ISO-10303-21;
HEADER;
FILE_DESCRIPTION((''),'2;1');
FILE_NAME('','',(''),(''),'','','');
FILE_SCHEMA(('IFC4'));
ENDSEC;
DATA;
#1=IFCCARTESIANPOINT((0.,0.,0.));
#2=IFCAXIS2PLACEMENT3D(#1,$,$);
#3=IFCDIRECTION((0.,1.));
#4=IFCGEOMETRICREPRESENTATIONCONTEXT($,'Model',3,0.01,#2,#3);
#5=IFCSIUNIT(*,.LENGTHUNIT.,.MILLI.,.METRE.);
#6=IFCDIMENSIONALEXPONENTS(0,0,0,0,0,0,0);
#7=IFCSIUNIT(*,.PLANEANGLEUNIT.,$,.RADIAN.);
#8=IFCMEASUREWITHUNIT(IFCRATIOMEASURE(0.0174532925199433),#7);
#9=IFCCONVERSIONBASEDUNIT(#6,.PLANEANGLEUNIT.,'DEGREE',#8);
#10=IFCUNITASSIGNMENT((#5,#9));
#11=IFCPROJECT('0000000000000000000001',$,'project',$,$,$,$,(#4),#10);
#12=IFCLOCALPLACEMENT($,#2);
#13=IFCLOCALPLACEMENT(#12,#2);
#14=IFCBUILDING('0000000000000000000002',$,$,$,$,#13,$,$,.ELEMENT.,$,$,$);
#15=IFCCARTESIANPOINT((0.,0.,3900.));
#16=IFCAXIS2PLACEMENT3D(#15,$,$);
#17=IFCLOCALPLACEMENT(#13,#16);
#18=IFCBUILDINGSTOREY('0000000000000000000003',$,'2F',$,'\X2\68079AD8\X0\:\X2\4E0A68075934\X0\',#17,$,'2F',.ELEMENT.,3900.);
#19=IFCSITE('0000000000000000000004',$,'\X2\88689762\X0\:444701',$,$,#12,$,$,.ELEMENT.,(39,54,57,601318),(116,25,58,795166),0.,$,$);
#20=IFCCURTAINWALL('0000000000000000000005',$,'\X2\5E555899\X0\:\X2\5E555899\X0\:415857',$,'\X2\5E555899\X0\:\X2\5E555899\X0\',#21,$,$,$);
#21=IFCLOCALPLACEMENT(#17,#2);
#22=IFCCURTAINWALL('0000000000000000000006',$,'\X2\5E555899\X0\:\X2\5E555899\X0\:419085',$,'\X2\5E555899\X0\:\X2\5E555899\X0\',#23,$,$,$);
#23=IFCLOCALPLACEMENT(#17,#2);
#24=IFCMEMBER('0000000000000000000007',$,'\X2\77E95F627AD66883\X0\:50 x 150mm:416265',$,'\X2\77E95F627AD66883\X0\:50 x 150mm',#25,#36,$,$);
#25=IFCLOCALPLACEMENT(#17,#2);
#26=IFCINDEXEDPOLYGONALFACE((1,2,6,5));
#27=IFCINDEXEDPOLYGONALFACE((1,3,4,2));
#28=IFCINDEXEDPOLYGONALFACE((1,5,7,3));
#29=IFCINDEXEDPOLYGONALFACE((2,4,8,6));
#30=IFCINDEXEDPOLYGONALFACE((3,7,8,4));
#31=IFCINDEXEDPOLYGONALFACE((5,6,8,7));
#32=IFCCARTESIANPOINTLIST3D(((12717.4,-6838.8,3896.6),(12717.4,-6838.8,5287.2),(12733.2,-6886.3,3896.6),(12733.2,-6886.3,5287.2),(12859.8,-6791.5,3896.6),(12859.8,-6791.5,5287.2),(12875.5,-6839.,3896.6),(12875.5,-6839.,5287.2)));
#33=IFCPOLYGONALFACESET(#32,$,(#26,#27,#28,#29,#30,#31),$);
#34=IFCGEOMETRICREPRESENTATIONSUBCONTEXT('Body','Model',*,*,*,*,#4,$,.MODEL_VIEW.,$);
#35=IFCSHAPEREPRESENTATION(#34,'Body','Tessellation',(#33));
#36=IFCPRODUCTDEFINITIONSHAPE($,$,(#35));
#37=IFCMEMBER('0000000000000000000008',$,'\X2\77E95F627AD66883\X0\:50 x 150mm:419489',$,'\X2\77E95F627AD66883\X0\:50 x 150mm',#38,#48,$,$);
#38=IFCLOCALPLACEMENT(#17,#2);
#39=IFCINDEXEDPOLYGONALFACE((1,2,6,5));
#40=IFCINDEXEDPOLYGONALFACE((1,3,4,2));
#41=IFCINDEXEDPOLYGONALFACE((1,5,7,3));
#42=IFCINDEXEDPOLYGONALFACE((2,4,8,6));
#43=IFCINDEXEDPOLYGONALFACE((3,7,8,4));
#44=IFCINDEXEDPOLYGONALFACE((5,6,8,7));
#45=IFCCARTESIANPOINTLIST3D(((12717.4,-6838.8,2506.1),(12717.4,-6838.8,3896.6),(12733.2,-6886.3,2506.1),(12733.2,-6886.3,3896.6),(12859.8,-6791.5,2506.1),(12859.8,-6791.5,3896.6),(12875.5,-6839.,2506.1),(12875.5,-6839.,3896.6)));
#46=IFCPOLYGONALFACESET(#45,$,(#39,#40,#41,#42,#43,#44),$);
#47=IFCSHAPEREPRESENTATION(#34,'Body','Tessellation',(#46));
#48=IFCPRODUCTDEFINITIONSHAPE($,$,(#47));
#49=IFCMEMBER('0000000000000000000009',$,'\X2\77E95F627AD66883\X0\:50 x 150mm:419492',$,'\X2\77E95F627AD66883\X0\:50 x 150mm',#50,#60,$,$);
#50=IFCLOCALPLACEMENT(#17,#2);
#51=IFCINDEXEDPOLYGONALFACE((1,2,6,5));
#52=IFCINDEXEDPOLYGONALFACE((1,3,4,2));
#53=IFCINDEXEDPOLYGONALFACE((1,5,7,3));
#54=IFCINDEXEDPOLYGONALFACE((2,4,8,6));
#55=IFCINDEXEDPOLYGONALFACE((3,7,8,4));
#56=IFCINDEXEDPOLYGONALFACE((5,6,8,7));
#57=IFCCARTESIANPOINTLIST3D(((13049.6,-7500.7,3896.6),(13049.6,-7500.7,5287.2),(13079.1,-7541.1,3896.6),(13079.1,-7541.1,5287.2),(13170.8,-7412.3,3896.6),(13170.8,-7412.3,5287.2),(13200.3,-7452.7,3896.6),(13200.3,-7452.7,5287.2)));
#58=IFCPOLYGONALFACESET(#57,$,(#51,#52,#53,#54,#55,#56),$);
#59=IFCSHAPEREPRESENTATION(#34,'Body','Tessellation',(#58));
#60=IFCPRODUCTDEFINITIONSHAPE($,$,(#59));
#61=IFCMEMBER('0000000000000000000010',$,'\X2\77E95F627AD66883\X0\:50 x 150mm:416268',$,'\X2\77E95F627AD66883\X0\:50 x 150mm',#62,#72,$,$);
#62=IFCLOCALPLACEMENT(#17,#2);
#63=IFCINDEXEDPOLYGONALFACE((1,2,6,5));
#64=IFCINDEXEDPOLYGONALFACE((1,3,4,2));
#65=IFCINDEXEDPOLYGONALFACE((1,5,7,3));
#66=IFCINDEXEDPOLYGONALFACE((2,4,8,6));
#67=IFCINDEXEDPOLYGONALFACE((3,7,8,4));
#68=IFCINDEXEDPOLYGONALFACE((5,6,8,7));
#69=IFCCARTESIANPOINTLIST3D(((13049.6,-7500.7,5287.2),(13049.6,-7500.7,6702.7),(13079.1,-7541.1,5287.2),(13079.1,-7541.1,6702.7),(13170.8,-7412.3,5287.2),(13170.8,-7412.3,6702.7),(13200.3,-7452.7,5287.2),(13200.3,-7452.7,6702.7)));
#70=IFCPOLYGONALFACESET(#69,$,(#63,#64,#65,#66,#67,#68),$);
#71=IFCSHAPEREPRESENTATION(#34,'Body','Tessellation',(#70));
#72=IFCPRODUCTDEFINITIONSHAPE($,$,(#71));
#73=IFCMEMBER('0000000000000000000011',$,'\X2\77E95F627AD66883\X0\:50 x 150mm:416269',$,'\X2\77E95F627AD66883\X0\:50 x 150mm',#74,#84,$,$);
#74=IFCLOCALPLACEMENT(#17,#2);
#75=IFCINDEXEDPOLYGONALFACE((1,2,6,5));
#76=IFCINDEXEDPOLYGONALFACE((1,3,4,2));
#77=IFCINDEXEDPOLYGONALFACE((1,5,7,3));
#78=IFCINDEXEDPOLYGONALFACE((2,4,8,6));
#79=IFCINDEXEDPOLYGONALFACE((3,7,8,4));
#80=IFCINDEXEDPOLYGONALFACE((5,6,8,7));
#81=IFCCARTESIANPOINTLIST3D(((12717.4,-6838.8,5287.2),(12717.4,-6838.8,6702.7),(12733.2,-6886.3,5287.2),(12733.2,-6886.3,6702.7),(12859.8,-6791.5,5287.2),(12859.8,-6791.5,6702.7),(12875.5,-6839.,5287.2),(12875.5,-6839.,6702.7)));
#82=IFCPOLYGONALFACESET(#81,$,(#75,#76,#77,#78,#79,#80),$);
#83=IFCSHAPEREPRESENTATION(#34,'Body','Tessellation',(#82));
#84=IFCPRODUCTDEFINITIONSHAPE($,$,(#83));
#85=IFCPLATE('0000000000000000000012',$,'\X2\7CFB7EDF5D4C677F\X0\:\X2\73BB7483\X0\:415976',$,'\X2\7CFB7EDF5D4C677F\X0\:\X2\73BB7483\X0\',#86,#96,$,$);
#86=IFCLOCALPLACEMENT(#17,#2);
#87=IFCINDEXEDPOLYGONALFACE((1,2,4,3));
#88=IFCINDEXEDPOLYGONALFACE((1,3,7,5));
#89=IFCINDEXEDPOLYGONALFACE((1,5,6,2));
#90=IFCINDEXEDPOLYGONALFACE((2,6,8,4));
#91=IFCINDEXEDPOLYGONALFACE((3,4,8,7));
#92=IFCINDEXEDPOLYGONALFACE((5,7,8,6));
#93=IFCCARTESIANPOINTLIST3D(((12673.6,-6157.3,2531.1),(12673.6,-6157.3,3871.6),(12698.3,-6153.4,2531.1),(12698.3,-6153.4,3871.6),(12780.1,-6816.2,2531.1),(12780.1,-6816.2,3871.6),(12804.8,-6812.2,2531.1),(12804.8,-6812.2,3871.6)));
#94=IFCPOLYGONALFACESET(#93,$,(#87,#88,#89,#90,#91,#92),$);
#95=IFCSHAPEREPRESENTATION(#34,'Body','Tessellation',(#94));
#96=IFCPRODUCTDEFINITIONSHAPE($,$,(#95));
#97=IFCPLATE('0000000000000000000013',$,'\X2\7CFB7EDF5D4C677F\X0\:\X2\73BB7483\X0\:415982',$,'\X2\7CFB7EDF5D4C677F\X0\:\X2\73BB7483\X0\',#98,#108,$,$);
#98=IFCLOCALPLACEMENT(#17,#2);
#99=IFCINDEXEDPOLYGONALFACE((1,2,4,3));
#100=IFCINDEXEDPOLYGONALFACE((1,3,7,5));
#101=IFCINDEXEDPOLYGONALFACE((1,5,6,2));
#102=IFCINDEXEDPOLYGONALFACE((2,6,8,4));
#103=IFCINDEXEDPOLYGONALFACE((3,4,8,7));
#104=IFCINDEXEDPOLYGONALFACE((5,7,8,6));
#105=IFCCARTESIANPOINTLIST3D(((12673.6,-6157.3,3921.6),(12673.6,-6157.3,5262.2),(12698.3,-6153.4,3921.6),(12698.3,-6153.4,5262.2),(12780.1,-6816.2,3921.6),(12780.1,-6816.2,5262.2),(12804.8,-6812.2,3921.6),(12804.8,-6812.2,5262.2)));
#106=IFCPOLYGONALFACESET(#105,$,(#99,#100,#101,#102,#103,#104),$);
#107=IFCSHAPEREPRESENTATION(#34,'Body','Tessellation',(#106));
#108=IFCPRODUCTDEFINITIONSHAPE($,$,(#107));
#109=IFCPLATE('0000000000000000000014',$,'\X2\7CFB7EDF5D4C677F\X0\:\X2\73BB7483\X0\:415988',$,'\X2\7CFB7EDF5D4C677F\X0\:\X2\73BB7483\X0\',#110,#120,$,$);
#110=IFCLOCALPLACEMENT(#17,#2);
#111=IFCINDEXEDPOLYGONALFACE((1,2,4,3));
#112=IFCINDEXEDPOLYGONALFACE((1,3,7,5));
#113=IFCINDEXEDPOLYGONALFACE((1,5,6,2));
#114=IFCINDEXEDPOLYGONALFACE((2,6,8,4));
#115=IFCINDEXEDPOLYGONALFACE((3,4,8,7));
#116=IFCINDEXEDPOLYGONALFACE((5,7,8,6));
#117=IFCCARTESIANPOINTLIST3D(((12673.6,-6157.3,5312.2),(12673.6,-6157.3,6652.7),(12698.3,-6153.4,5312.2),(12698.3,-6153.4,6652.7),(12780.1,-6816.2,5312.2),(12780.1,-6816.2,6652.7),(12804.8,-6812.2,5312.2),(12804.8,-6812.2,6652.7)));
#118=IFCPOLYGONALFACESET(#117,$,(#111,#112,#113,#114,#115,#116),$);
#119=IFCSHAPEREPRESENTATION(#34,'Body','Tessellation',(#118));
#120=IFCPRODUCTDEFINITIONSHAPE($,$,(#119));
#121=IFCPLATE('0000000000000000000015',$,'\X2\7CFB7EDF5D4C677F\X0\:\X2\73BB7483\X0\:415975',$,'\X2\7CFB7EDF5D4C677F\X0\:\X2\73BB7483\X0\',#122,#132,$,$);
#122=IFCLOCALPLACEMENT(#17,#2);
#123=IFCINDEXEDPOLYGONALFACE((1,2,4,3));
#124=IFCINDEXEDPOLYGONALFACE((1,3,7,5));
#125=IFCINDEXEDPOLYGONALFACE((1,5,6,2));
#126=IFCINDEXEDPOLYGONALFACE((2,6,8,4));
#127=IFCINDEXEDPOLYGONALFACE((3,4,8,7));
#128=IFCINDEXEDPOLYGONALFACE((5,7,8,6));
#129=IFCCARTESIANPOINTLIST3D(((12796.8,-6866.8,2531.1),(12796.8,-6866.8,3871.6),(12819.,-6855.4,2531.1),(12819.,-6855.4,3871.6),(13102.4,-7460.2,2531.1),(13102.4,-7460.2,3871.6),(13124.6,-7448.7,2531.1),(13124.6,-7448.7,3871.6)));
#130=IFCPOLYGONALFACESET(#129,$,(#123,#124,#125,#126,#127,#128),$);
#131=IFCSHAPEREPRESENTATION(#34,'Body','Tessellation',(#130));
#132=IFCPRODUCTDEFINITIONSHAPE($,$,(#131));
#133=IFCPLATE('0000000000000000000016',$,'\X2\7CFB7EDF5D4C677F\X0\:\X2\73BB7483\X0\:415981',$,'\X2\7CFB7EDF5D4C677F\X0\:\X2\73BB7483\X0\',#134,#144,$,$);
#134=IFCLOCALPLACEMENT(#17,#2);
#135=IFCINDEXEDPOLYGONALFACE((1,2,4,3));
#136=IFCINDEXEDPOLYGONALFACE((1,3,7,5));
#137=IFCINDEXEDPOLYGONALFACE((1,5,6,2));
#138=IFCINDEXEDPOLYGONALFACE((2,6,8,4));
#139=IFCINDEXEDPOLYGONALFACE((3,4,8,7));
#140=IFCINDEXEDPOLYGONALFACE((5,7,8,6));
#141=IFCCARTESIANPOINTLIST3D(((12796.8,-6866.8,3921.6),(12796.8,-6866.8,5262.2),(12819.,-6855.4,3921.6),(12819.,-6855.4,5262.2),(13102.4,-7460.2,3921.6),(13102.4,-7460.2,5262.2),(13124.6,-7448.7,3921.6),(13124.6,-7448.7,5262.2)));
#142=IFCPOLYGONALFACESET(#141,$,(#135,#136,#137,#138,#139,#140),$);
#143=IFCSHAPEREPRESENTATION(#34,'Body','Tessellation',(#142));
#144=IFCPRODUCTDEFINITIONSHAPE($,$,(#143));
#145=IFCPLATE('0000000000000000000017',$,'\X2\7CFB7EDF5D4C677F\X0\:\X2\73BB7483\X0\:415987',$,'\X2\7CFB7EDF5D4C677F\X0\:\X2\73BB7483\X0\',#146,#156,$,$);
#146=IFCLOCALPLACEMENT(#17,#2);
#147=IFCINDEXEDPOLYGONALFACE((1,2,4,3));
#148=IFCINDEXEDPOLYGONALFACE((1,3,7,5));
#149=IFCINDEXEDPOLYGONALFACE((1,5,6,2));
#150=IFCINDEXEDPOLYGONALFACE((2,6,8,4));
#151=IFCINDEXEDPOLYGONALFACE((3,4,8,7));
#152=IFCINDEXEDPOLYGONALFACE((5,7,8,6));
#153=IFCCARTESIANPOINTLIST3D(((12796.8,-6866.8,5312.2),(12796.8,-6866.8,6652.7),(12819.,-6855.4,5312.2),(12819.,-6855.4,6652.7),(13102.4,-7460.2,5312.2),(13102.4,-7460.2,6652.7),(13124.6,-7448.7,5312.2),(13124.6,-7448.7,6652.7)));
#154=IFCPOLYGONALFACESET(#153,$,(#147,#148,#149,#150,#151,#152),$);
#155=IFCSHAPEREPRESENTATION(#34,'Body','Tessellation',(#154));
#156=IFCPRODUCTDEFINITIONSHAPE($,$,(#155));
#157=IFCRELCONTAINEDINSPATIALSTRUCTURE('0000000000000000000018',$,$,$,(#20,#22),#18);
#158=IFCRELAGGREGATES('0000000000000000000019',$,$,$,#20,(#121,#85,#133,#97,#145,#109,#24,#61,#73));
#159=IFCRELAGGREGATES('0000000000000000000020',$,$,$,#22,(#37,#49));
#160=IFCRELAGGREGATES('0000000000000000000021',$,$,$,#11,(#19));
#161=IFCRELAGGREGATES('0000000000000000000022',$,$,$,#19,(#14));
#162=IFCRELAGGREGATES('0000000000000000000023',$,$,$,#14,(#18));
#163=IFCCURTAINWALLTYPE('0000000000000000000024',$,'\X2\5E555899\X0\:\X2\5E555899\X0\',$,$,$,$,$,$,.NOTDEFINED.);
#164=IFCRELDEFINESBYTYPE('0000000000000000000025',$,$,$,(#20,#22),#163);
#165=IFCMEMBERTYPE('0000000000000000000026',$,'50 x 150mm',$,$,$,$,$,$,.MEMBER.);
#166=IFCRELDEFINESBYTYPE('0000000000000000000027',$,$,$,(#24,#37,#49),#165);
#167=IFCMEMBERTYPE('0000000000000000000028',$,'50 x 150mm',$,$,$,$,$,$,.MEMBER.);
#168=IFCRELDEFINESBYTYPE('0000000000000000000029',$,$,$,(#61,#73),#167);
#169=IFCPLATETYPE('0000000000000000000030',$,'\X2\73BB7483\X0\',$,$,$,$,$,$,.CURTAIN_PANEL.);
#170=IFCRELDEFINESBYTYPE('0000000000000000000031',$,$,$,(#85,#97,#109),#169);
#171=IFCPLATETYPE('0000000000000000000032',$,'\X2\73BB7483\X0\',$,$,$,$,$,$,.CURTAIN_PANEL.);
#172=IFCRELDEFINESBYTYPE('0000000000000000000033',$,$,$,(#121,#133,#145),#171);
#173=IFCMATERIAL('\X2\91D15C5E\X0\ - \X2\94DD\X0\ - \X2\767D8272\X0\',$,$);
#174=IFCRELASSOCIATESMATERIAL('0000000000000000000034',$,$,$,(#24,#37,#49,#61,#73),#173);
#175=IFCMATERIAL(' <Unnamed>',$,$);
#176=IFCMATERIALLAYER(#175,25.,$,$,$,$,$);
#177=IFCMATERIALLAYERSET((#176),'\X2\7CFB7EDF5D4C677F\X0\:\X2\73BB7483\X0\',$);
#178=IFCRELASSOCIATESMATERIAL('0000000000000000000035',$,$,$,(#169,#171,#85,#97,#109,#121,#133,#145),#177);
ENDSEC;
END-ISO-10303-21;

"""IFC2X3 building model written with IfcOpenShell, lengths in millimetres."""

from ifc_helpers import new_model, entity, si_unit, converted_unit, direction, frame, frame_2d, origin, origin_2d_with_axis, place, context, subcontext, project, spatial, rectangle, extrude, source, transform, mapped, material, layer, layer_set, layer_usage, type_object, type_shapes, element, aggregate, save


model = new_model("IFC2X3")

# Units and contexts
model_context = context("Model", 3, precision=0.01, world=origin(), true_north=direction((0.0, 1.0)))
body_context = subcontext(model_context, "Body", "Model", "MODEL_VIEW")
ifc_project = project(units=[si_unit("LENGTHUNIT", "METRE", prefix="MILLI"), converted_unit("PLANEANGLEUNIT", "DEGREE", entity("IfcRatioMeasure", 0.0174532925199433), si_unit("PLANEANGLEUNIT", "RADIAN"), dimensions=[0, 0, 0, 0, 0, 0, 0])], contexts=[model_context])

# Site, building, storey
site_placement = place(None, origin())
site = spatial("IfcSite", under=ifc_project, at=site_placement, Name="表面:444701", CompositionType="ELEMENT", RefLatitude=(39, 54, 57, 601318), RefLongitude=(116, 25, 58, 795166), RefElevation=0.0)
building_placement = place(site_placement, origin())
building = spatial("IfcBuilding", under=site, at=building_placement, CompositionType="ELEMENT")
storey_placement = place(building_placement, frame((0.0, 0.0, 3900.0)))
storey = spatial("IfcBuildingStorey", under=building, at=storey_placement, Name="2F", ObjectType="标高:上标头", LongName="2F", CompositionType="ELEMENT", Elevation=3900.0)

# Curtain walls
curtain_wall_type = type_object("IfcCurtainWallType", Name="幕墙:幕墙", PredefinedType="NOTDEFINED")
curtain_wall_1_placement = place(storey_placement, frame((0.0, 0.0, -3900.0)))
curtain_wall_1 = element("IfcCurtainWall", 1, at=curtain_wall_1_placement, inside=storey, type_object=curtain_wall_type, Name="幕墙:幕墙:415857", ObjectType="幕墙:幕墙")
ifc_material_1 = material(Name="金属 - 铝 - 白色")
curtain_wall_2_placement = place(storey_placement, frame((0.0, 0.0, -3900.0)))
curtain_wall_2 = element("IfcCurtainWall", 2, at=curtain_wall_2_placement, inside=storey, type_object=curtain_wall_type, Name="幕墙:幕墙:419085", ObjectType="幕墙:幕墙")

# Members
member_type_1 = type_object("IfcMemberType", Name="50 x 150mm", PredefinedType="MEMBER")
shared_shape_1 = source(origin(), body_context, "Body", "SweptSolid", [
    extrude(rectangle(XDim=150.0, YDim=50.0, at=origin_2d_with_axis()), frame((0.0, 0.0, -1390.5), z_axis=(0.0, 0.0, 1.0), x_axis=(0.0, -1.0, 0.0)), (0.0, 0.0, 1.0), 1390.5),
])
type_shapes(member_type_1, [shared_shape_1])
member_1_placement = place(storey_placement, frame((12796.5, -6838.9, 3896.6), z_axis=(0.0, 0.0, -1.0), x_axis=(-0.315223, 0.949018, 0.0)))
member_1 = element("IfcMember", 3, at=member_1_placement, type_object=member_type_1, material=ifc_material_1, Name="矩形竖梃:50 x 150mm:416265", ObjectType="矩形竖梃:50 x 150mm", context=body_context, shape_type="MappedRepresentation", body=[
    mapped(shared_shape_1, transform((0.0, 0.0, 0.0), scale=1.0)),
])
member_2_placement = place(storey_placement, frame((12796.5, -6838.9, 2506.1), z_axis=(0.0, 0.0, -1.0), x_axis=(-0.315223, 0.949018, 0.0)))
member_2 = element("IfcMember", 4, at=member_2_placement, type_object=member_type_1, material=ifc_material_1, Name="矩形竖梃:50 x 150mm:419489", ObjectType="矩形竖梃:50 x 150mm", context=body_context, shape_type="MappedRepresentation", body=[
    mapped(shared_shape_1, transform((0.0, 0.0, 0.0), scale=1.0)),
])
member_3_placement = place(storey_placement, frame((13125.0, -7476.7, 3896.6), z_axis=(0.0, 0.0, -1.0), x_axis=(-0.589546, 0.807735, 0.0)))
member_3 = element("IfcMember", 5, at=member_3_placement, type_object=member_type_1, material=ifc_material_1, Name="矩形竖梃:50 x 150mm:419492", ObjectType="矩形竖梃:50 x 150mm", context=body_context, shape_type="MappedRepresentation", body=[
    mapped(shared_shape_1, transform((0.0, 0.0, 0.0), scale=1.0)),
])
member_type_2 = type_object("IfcMemberType", Name="50 x 150mm", PredefinedType="MEMBER")
shared_shape_2 = source(origin(), body_context, "Body", "SweptSolid", [
    extrude(rectangle(XDim=150.0, YDim=50.0, at=origin_2d_with_axis()), frame((0.0, 0.0, -1415.5), z_axis=(0.0, 0.0, 1.0), x_axis=(0.0, -1.0, 0.0)), (0.0, 0.0, 1.0), 1415.5),
])
type_shapes(member_type_2, [shared_shape_2])
member_4_placement = place(storey_placement, frame((13125.0, -7476.7, 5287.2), z_axis=(0.0, 0.0, -1.0), x_axis=(-0.589546, 0.807735, 0.0)))
member_4 = element("IfcMember", 6, at=member_4_placement, type_object=member_type_2, material=ifc_material_1, Name="矩形竖梃:50 x 150mm:416268", ObjectType="矩形竖梃:50 x 150mm", context=body_context, shape_type="MappedRepresentation", body=[
    mapped(shared_shape_2, transform((0.0, 0.0, 0.0), scale=1.0)),
])
member_5_placement = place(storey_placement, frame((12796.5, -6838.9, 5287.2), z_axis=(0.0, 0.0, -1.0), x_axis=(-0.315223, 0.949018, 0.0)))
member_5 = element("IfcMember", 7, at=member_5_placement, type_object=member_type_2, material=ifc_material_1, Name="矩形竖梃:50 x 150mm:416269", ObjectType="矩形竖梃:50 x 150mm", context=body_context, shape_type="MappedRepresentation", body=[
    mapped(shared_shape_2, transform((0.0, 0.0, 0.0), scale=1.0)),
])

# Plates
ifc_material_2 = material(Name=" <Unnamed>")
ifc_layer = layer(ifc_material_2, 25.0)
ifc_layer_set = layer_set([ifc_layer], Name="系统嵌板:玻璃")
ifc_layer_usage_1 = layer_usage(ifc_layer_set, "AXIS3", "POSITIVE", 0.0)
plate_type_1 = type_object("IfcPlateType", Name="玻璃", PredefinedType="CURTAIN_PANEL", material=ifc_layer_set)
shared_shape_3 = source(origin(), body_context, "Body", "SweptSolid", [
    extrude(rectangle(XDim=25.0, YDim=667.4, at=frame_2d((0.0, 0.0), x_axis=(1.0, 0.0))), frame((0.0, 0.0, 0.0), z_axis=(0.0, 0.0, 1.0), x_axis=(0.0, 1.0, 0.0)), (0.0, 0.0, 1.0), 1340.5),
])
type_shapes(plate_type_1, [shared_shape_3])
plate_1_placement = place(curtain_wall_1_placement, frame((12739.2, -6484.8, 6431.1), z_axis=(0.0, 0.0, 1.0), x_axis=(-0.15966, 0.987172, 0.0)))
plate_1 = element("IfcPlate", 8, at=plate_1_placement, type_object=plate_type_1, material=ifc_layer_usage_1, Name="系统嵌板:玻璃:415976", ObjectType="系统嵌板:玻璃", context=body_context, shape_type="MappedRepresentation", body=[
    mapped(shared_shape_3, transform((0.0, 0.0, 0.0), scale=1.0)),
])
ifc_layer_usage_2 = layer_usage(ifc_layer_set, "AXIS3", "POSITIVE", 0.0)
plate_2_placement = place(curtain_wall_1_placement, frame((12739.2, -6484.8, 7821.6), z_axis=(0.0, 0.0, 1.0), x_axis=(-0.15966, 0.987172, 0.0)))
plate_2 = element("IfcPlate", 9, at=plate_2_placement, type_object=plate_type_1, material=ifc_layer_usage_2, Name="系统嵌板:玻璃:415982", ObjectType="系统嵌板:玻璃", context=body_context, shape_type="MappedRepresentation", body=[
    mapped(shared_shape_3, transform((0.0, 0.0, 0.0), scale=1.0)),
])
ifc_layer_usage_3 = layer_usage(ifc_layer_set, "AXIS3", "POSITIVE", 0.0)
plate_3_placement = place(curtain_wall_1_placement, frame((12739.2, -6484.8, 9212.2), z_axis=(0.0, 0.0, 1.0), x_axis=(-0.15966, 0.987172, 0.0)))
plate_3 = element("IfcPlate", 10, at=plate_3_placement, type_object=plate_type_1, material=ifc_layer_usage_3, Name="系统嵌板:玻璃:415988", ObjectType="系统嵌板:玻璃", context=body_context, shape_type="MappedRepresentation", body=[
    mapped(shared_shape_3, transform((0.0, 0.0, 0.0), scale=1.0)),
])
ifc_layer_usage_4 = layer_usage(ifc_layer_set, "AXIS3", "POSITIVE", 0.0)
plate_type_2 = type_object("IfcPlateType", Name="玻璃", PredefinedType="CURTAIN_PANEL", material=ifc_layer_set)
shared_shape_4 = source(origin(), body_context, "Body", "SweptSolid", [
    extrude(rectangle(XDim=25.0, YDim=667.4, at=frame_2d((0.0, 0.0), x_axis=(1.0, 0.0))), frame((0.0, 0.0, 0.0), z_axis=(0.0, 0.0, 1.0), x_axis=(0.0, 1.0, 0.0)), (0.0, 0.0, 1.0), 1340.5),
])
type_shapes(plate_type_2, [shared_shape_4])
plate_4_placement = place(curtain_wall_1_placement, frame((12960.7, -7157.8, 6431.1), z_axis=(0.0, 0.0, 1.0), x_axis=(-0.457867, 0.889021, 0.0)))
plate_4 = element("IfcPlate", 11, at=plate_4_placement, type_object=plate_type_2, material=ifc_layer_usage_4, Name="系统嵌板:玻璃:415975", ObjectType="系统嵌板:玻璃", context=body_context, shape_type="MappedRepresentation", body=[
    mapped(shared_shape_4, transform((0.0, 0.0, 0.0), scale=1.0)),
])
ifc_layer_usage_5 = layer_usage(ifc_layer_set, "AXIS3", "POSITIVE", 0.0)
plate_5_placement = place(curtain_wall_1_placement, frame((12960.7, -7157.8, 7821.6), z_axis=(0.0, 0.0, 1.0), x_axis=(-0.457867, 0.889021, 0.0)))
plate_5 = element("IfcPlate", 12, at=plate_5_placement, type_object=plate_type_2, material=ifc_layer_usage_5, Name="系统嵌板:玻璃:415981", ObjectType="系统嵌板:玻璃", context=body_context, shape_type="MappedRepresentation", body=[
    mapped(shared_shape_4, transform((0.0, 0.0, 0.0), scale=1.0)),
])
ifc_layer_usage_6 = layer_usage(ifc_layer_set, "AXIS3", "POSITIVE", 0.0)
plate_6_placement = place(curtain_wall_1_placement, frame((12960.7, -7157.8, 9212.2), z_axis=(0.0, 0.0, 1.0), x_axis=(-0.457867, 0.889021, 0.0)))
plate_6 = element("IfcPlate", 13, at=plate_6_placement, type_object=plate_type_2, material=ifc_layer_usage_6, Name="系统嵌板:玻璃:415987", ObjectType="系统嵌板:玻璃", context=body_context, shape_type="MappedRepresentation", body=[
    mapped(shared_shape_4, transform((0.0, 0.0, 0.0), scale=1.0)),
])
aggregate(curtain_wall_1, [plate_4, plate_1, plate_5, plate_2, plate_6, plate_3, member_1, member_4, member_5])
aggregate(curtain_wall_2, [member_2, member_3])

save(model, "model.ifc")
